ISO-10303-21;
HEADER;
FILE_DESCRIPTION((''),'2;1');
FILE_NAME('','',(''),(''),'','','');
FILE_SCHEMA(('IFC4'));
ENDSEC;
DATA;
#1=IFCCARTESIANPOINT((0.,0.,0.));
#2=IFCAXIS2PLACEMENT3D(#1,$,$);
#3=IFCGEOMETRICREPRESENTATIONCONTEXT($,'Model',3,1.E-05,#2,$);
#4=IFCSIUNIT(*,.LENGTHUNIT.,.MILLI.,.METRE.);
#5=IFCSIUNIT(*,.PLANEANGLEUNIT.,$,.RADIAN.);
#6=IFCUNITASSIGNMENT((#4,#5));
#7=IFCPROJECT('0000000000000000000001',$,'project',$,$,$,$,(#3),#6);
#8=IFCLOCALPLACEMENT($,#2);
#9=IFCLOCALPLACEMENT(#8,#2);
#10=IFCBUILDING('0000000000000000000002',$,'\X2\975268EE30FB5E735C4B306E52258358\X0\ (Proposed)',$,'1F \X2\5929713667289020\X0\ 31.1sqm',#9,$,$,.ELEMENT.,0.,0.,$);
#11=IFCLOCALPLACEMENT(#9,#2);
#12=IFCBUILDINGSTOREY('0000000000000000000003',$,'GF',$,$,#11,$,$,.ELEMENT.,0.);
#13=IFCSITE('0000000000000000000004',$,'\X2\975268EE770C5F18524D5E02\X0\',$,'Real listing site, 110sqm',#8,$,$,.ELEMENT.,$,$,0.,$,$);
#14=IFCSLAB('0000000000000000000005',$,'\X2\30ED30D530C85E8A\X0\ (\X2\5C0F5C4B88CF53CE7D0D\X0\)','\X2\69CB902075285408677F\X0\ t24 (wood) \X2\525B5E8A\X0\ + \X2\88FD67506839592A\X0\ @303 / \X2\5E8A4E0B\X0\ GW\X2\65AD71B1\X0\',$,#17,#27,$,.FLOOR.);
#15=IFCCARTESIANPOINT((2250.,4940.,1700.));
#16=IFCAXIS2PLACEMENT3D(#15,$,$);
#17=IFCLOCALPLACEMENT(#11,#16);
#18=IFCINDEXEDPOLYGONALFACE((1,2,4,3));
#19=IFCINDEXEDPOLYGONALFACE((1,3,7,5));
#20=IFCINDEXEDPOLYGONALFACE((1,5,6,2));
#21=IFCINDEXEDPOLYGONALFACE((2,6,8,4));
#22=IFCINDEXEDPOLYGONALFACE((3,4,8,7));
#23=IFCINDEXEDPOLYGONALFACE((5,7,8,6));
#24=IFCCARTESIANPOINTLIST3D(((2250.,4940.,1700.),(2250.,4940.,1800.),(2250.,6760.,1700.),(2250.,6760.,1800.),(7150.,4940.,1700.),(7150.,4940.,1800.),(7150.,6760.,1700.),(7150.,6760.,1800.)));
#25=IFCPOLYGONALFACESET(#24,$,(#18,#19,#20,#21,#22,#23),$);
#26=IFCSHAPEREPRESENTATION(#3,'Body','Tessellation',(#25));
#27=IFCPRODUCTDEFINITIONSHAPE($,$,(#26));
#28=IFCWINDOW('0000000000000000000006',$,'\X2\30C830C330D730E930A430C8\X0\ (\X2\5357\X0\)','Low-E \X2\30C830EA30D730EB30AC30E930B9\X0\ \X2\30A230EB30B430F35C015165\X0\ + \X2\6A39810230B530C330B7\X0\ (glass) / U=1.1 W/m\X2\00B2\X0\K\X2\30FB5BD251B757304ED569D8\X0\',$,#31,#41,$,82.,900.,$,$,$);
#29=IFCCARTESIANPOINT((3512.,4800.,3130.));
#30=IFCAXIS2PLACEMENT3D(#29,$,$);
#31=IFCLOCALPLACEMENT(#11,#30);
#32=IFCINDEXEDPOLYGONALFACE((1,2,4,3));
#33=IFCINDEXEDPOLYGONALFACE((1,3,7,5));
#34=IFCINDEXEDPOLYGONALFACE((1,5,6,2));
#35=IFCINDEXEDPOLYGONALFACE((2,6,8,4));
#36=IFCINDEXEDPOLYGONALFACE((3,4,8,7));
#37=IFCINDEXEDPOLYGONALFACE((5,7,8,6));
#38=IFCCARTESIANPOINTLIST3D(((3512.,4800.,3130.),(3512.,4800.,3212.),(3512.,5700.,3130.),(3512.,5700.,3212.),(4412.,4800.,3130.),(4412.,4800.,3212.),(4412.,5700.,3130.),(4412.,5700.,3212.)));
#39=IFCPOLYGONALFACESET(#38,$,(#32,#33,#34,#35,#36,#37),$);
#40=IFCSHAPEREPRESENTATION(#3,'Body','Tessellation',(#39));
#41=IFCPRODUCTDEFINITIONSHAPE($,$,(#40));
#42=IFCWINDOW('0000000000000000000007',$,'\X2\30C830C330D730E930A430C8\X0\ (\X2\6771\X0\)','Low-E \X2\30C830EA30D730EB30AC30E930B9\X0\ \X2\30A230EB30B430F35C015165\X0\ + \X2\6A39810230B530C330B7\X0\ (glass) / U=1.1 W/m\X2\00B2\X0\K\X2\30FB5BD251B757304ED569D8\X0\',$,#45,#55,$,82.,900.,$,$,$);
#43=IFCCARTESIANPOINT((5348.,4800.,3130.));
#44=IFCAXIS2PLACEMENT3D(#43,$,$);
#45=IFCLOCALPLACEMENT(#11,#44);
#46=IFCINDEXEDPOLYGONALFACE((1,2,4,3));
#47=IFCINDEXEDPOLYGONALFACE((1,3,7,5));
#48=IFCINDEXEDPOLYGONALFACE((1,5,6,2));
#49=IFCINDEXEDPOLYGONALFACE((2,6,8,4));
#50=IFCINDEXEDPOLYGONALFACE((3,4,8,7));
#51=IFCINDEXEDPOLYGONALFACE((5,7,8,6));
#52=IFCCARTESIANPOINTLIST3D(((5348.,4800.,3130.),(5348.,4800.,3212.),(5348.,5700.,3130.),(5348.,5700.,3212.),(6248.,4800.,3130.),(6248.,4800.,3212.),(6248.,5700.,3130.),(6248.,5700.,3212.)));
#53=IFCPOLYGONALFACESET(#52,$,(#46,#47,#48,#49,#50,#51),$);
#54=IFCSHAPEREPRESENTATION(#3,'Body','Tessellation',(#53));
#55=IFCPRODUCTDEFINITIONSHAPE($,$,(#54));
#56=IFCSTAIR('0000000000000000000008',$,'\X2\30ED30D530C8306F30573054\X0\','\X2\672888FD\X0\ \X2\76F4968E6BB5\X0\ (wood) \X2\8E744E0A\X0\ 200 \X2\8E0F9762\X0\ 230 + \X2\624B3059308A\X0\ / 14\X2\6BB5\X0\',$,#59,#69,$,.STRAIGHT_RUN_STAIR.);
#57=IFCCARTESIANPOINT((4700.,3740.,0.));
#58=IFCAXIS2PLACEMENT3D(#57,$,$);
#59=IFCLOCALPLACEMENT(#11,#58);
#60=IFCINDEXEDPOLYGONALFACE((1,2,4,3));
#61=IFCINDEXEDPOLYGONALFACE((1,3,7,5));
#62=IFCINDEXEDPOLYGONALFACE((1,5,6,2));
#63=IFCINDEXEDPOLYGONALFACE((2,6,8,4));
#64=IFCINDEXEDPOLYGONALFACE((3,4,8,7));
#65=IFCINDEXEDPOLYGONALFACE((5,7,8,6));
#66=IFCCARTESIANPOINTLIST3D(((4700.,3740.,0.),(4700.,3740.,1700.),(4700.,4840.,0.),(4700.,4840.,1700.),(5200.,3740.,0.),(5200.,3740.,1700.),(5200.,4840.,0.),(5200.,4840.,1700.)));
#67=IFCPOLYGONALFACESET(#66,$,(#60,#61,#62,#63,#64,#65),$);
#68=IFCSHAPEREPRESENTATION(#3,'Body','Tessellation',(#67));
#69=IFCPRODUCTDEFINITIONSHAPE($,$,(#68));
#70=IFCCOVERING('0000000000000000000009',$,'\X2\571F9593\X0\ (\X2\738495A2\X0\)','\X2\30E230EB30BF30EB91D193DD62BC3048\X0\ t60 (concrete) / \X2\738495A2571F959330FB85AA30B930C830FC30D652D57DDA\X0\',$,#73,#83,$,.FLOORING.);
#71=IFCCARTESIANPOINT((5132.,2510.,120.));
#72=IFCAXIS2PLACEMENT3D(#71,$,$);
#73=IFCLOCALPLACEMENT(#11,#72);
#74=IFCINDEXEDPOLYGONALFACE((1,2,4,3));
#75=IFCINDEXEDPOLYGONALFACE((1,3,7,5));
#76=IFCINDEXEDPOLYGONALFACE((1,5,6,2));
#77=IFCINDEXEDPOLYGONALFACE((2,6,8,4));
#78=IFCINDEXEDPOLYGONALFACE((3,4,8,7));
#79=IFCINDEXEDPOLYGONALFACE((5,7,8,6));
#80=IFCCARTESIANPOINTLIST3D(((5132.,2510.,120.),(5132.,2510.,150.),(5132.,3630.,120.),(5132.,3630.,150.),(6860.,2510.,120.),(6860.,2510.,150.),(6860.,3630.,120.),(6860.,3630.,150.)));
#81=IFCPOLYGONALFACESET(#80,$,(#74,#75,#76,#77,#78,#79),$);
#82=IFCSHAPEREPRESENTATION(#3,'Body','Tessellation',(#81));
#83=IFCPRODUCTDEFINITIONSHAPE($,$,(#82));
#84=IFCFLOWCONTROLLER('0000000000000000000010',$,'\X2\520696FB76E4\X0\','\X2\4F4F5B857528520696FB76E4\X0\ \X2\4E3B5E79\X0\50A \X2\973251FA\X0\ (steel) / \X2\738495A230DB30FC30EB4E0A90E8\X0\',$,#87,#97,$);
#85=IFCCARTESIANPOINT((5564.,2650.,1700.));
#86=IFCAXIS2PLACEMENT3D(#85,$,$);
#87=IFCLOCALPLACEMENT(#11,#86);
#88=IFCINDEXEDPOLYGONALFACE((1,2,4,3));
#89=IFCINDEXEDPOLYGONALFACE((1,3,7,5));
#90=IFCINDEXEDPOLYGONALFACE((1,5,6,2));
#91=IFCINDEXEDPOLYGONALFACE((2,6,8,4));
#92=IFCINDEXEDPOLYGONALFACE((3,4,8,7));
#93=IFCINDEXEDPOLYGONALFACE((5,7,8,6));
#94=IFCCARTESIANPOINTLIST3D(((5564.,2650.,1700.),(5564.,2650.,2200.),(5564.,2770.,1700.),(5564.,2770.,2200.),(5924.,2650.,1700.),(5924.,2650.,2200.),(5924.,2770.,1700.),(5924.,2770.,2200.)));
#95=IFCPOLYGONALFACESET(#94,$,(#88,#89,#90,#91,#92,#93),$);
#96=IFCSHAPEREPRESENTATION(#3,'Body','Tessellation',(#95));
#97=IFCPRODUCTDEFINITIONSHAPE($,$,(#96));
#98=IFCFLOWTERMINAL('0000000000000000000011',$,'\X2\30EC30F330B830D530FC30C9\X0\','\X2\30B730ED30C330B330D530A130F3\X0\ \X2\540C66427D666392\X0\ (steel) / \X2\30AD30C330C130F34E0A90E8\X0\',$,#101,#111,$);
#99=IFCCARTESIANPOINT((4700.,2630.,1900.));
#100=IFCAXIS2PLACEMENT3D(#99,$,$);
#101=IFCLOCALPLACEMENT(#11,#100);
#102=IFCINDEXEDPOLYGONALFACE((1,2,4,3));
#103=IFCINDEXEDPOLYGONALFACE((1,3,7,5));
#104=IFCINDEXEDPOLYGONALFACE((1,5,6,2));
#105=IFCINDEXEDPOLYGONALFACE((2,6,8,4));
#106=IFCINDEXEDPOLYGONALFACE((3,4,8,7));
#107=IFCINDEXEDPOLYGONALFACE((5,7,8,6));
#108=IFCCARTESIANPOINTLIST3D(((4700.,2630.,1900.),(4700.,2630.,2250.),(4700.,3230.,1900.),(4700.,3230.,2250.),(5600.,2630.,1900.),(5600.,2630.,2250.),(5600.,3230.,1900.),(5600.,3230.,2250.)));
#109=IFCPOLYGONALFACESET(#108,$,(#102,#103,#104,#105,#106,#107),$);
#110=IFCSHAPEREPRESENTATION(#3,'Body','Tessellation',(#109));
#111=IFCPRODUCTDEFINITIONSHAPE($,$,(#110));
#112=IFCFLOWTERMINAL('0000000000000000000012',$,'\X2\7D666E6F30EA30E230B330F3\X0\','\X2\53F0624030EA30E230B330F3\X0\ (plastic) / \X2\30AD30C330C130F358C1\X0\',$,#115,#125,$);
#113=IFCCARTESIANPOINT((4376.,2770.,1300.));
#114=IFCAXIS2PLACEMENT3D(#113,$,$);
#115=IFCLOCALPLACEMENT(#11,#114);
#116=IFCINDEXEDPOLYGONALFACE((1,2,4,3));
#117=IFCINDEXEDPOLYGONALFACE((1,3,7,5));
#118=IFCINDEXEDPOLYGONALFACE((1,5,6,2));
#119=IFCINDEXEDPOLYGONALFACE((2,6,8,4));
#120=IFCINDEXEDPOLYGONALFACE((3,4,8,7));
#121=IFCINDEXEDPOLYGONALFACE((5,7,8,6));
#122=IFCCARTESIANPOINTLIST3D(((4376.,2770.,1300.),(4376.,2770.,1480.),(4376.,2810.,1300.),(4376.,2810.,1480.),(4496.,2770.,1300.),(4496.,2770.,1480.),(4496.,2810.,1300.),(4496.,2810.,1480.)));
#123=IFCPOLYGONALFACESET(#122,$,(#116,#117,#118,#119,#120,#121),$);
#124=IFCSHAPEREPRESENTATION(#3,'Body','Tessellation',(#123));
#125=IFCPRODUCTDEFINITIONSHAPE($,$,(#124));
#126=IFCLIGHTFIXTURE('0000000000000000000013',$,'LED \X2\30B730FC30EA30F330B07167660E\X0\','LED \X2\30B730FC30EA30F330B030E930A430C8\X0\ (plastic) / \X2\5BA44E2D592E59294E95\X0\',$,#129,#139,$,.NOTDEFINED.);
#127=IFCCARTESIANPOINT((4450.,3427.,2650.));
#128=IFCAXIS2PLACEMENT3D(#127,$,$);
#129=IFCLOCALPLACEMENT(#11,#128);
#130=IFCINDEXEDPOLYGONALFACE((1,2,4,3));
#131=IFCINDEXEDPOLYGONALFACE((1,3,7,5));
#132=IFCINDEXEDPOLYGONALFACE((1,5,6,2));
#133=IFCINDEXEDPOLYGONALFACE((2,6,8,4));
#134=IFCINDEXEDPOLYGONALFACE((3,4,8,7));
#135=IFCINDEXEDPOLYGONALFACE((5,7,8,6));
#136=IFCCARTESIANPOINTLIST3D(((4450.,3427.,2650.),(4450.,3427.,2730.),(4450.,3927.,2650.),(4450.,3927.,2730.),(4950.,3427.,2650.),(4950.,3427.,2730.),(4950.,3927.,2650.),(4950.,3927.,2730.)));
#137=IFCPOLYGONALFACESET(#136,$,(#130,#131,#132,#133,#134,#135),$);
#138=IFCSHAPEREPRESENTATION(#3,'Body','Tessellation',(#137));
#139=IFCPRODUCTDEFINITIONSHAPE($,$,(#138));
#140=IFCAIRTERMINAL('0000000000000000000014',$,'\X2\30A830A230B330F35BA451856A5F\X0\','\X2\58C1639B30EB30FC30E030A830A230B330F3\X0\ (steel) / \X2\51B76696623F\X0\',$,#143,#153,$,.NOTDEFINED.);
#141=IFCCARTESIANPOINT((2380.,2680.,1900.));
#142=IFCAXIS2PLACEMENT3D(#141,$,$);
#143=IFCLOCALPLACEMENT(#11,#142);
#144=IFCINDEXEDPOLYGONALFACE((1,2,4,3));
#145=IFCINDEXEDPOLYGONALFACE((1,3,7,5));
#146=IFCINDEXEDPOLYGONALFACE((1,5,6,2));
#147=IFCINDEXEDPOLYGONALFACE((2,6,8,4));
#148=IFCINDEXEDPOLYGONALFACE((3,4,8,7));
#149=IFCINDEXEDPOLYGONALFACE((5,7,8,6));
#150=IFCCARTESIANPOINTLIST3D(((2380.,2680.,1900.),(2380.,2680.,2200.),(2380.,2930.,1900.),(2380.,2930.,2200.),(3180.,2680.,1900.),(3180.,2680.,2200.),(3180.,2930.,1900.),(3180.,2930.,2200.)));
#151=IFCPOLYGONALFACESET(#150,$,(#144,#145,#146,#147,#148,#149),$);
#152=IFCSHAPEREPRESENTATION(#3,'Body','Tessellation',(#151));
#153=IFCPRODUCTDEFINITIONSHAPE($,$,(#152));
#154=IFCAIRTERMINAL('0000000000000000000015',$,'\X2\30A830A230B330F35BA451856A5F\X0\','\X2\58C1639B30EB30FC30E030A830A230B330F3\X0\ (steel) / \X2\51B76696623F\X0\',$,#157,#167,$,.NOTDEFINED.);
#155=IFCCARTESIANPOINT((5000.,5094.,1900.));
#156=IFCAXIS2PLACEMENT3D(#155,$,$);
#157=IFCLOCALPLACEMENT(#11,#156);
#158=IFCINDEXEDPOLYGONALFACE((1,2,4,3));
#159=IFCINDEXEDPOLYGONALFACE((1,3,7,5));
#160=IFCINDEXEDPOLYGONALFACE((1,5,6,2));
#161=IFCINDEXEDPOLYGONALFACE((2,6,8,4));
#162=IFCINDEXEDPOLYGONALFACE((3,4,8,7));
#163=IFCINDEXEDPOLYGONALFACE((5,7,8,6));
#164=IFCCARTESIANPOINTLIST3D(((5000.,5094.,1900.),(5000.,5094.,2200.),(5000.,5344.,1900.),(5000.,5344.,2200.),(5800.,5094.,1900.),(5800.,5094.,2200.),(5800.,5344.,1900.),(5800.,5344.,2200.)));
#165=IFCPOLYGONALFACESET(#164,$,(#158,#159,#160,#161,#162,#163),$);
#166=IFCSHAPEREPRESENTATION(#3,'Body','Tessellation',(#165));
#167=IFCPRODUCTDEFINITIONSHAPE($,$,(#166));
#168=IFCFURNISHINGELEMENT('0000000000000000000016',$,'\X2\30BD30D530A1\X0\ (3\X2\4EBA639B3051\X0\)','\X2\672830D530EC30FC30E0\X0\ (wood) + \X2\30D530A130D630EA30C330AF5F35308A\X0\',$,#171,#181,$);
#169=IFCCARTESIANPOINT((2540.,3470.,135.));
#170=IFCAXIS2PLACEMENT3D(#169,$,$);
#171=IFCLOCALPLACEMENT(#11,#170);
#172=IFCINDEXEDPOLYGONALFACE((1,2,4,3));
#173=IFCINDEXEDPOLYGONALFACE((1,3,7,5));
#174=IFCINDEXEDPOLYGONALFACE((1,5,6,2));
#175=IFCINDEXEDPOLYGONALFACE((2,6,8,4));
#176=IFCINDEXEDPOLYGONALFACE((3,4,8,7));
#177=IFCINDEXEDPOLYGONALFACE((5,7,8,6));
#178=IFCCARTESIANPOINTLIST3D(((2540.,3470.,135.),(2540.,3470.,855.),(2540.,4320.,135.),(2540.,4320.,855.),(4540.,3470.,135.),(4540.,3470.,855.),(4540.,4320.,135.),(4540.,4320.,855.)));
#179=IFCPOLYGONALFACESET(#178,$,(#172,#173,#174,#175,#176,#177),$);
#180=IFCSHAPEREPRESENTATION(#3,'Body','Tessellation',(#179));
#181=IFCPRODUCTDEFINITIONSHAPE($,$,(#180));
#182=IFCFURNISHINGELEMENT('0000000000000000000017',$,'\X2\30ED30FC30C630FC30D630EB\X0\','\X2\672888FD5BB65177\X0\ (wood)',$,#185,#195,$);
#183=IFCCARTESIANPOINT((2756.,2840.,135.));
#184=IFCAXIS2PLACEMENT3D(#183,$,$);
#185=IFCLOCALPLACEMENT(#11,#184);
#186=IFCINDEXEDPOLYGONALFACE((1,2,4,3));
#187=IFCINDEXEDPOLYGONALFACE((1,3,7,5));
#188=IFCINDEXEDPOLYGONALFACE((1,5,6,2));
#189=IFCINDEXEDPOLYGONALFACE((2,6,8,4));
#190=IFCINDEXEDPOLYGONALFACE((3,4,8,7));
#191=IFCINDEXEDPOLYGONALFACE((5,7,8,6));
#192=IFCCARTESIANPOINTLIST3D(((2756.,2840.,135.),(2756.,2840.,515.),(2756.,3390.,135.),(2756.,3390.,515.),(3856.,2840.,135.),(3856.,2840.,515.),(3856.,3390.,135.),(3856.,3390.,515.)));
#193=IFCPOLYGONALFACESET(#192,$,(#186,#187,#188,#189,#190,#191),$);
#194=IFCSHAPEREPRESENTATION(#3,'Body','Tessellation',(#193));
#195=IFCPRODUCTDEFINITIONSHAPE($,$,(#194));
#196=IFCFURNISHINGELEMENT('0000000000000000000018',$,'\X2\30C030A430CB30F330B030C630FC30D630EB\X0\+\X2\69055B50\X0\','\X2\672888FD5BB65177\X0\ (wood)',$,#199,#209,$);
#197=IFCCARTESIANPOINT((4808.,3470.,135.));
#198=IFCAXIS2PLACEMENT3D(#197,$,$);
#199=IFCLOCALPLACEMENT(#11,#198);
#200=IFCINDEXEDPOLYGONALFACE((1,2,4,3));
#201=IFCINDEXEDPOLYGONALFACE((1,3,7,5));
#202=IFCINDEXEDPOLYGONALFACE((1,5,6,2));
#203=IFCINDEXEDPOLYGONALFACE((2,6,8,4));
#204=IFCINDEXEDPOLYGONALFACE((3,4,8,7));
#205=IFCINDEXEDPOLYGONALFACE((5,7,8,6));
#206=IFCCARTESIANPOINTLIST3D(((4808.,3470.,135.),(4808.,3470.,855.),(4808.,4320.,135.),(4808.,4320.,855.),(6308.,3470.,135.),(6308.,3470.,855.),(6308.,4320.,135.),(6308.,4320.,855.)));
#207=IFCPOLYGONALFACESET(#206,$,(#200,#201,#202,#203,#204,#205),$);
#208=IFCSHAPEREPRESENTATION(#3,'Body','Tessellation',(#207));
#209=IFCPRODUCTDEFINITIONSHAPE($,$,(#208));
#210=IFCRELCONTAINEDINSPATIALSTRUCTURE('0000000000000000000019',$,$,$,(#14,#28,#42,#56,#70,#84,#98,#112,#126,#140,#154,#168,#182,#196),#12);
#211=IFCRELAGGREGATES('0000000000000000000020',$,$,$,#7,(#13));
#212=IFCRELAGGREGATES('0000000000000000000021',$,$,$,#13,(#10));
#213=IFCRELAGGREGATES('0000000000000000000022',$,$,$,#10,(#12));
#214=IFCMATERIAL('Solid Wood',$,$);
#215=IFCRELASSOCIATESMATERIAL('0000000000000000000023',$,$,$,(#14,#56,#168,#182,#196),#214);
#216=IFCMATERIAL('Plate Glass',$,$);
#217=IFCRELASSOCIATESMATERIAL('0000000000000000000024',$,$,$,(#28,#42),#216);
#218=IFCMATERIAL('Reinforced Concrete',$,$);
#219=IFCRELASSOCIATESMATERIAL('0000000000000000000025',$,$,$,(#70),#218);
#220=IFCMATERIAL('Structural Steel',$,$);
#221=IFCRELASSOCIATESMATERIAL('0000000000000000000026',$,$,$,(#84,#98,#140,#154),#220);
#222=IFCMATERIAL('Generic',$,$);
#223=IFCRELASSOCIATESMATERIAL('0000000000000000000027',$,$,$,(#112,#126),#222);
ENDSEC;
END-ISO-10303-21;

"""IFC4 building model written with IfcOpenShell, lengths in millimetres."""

from ifc_helpers import new_model, si_unit, frame, frame_2d, origin, place, context, project, spatial, rectangle, extrude, material, element, save


model = new_model("IFC4")

# Units and contexts
model_context = context("Model", 3, precision=1e-05, world=origin())
ifc_project = project(units=[si_unit("LENGTHUNIT", "METRE", prefix="MILLI"), si_unit("PLANEANGLEUNIT", "RADIAN")], contexts=[model_context])

# Site, building, storey
site_placement = place(None, origin())
site = spatial("IfcSite", under=ifc_project, at=site_placement, Name="青森県弘前市", ObjectType="Real listing site, 110sqm", CompositionType="ELEMENT", RefElevation=0.0)
building_placement = place(site_placement, origin())
building = spatial("IfcBuilding", under=site, at=building_placement, Name="青森・平屋の別荘 (Proposed)", ObjectType="1F 天然木造 31.1sqm", CompositionType="ELEMENT", ElevationOfRefHeight=0.0, ElevationOfTerrain=0.0)
storey_placement = place(building_placement, origin())
storey = spatial("IfcBuildingStorey", under=building, at=storey_placement, Name="GF", CompositionType="ELEMENT", Elevation=0.0)

# Shared definitions
ifc_material_1 = material(Name="Solid Wood")

# Slab
slab_placement = place(storey_placement, frame((2250.0, 4940.0, 1700.0)))
element("IfcSlab", 1, at=slab_placement, inside=storey, material=ifc_material_1, Name="ロフト床 (小屋裏収納)", Description="構造用合板 t24 (wood) 剛床 + 製材根太 @303 / 床下 GW断熱", PredefinedType="FLOOR", context=model_context, shape_type="SweptSolid", body=[
    extrude(rectangle(XDim=4900.0, YDim=1820.0, at=frame_2d((2450.0, 910.0))), frame((2250.0, 4940.0, 1700.0)), (0.0, 0.0, 1.0), 100.0),
])

# Windows
ifc_material_2 = material(Name="Plate Glass")
window_1_placement = place(storey_placement, frame((3512.0, 4800.0, 3130.0)))
element("IfcWindow", 2, at=window_1_placement, inside=storey, material=ifc_material_2, Name="トップライト (南)", Description="Low-E トリプルガラス アルゴン封入 + 樹脂サッシ (glass) / U=1.1 W/m²K・寒冷地仕様", OverallHeight=82.0, OverallWidth=900.0, context=model_context, shape_type="SweptSolid", body=[
    extrude(rectangle(XDim=900.0, YDim=900.0, at=frame_2d((450.0, 450.0))), frame((3512.0, 4800.0, 3130.0)), (0.0, 0.0, 1.0), 82.0),
])
window_2_placement = place(storey_placement, frame((5348.0, 4800.0, 3130.0)))
element("IfcWindow", 3, at=window_2_placement, inside=storey, material=ifc_material_2, Name="トップライト (東)", Description="Low-E トリプルガラス アルゴン封入 + 樹脂サッシ (glass) / U=1.1 W/m²K・寒冷地仕様", OverallHeight=82.0, OverallWidth=900.0, context=model_context, shape_type="SweptSolid", body=[
    extrude(rectangle(XDim=900.0, YDim=900.0, at=frame_2d((450.0, 450.0))), frame((5348.0, 4800.0, 3130.0)), (0.0, 0.0, 1.0), 82.0),
])

# Stair
stair_placement = place(storey_placement, frame((4700.0, 3740.0, 0.0)))
element("IfcStair", 4, at=stair_placement, inside=storey, material=ifc_material_1, Name="ロフトはしご", Description="木製 直階段 (wood) 蹴上 200 踏面 230 + 手すり / 14段", PredefinedType="STRAIGHT_RUN_STAIR", context=model_context, shape_type="SweptSolid", body=[
    extrude(rectangle(XDim=500.0, YDim=1100.0, at=frame_2d((250.0, 550.0))), frame((4700.0, 3740.0, 0.0)), (0.0, 0.0, 1.0), 1700.0),
])

# Covering
ifc_material_3 = material(Name="Reinforced Concrete")
covering_placement = place(storey_placement, frame((5132.0, 2510.0, 120.0)))
element("IfcCovering", 5, at=covering_placement, inside=storey, material=ifc_material_3, Name="土間 (玄関)", Description="モルタル金鏝押え t60 (concrete) / 玄関土間・薪ストーブ動線", PredefinedType="FLOORING", context=model_context, shape_type="SweptSolid", body=[
    extrude(rectangle(XDim=1728.0, YDim=1120.0, at=frame_2d((864.0, 560.0))), frame((5132.0, 2510.0, 120.0)), (0.0, 0.0, 1.0), 30.0),
])

# Flow controller
ifc_material_4 = material(Name="Structural Steel")
flow_controller_placement = place(storey_placement, frame((5564.0, 2650.0, 1700.0)))
element("IfcFlowController", 6, at=flow_controller_placement, inside=storey, material=ifc_material_4, Name="分電盤", Description="住宅用分電盤 主幹50A 露出 (steel) / 玄関ホール上部", context=model_context, shape_type="SweptSolid", body=[
    extrude(rectangle(XDim=360.0, YDim=120.0, at=frame_2d((180.0, 60.0))), frame((5564.0, 2650.0, 1700.0)), (0.0, 0.0, 1.0), 500.0),
])

# Flow terminals
flow_terminal_1_placement = place(storey_placement, frame((4700.0, 2630.0, 1900.0)))
element("IfcFlowTerminal", 7, at=flow_terminal_1_placement, inside=storey, material=ifc_material_4, Name="レンジフード", Description="シロッコファン 同時給排 (steel) / キッチン上部", context=model_context, shape_type="SweptSolid", body=[
    extrude(rectangle(XDim=900.0, YDim=600.0, at=frame_2d((450.0, 300.0))), frame((4700.0, 2630.0, 1900.0)), (0.0, 0.0, 1.0), 350.0),
])
ifc_material_5 = material(Name="Generic")
flow_terminal_2_placement = place(storey_placement, frame((4376.0, 2770.0, 1300.0)))
element("IfcFlowTerminal", 8, at=flow_terminal_2_placement, inside=storey, material=ifc_material_5, Name="給湯リモコン", Description="台所リモコン (plastic) / キッチン壁", context=model_context, shape_type="SweptSolid", body=[
    extrude(rectangle(XDim=120.0, YDim=40.0, at=frame_2d((60.0, 20.0))), frame((4376.0, 2770.0, 1300.0)), (0.0, 0.0, 1.0), 180.0),
])

# Light fixture
light_fixture_placement = place(storey_placement, frame((4450.0, 3427.0, 2650.0)))
element("IfcLightFixture", 9, at=light_fixture_placement, inside=storey, material=ifc_material_5, Name="LED シーリング照明", Description="LED シーリングライト (plastic) / 室中央天井", PredefinedType="NOTDEFINED", context=model_context, shape_type="SweptSolid", body=[
    extrude(rectangle(XDim=500.0, YDim=500.0, at=frame_2d((250.0, 250.0))), frame((4450.0, 3427.0, 2650.0)), (0.0, 0.0, 1.0), 80.0),
])

# Air terminals
air_terminal_1_placement = place(storey_placement, frame((2380.0, 2680.0, 1900.0)))
element("IfcAirTerminal", 10, at=air_terminal_1_placement, inside=storey, material=ifc_material_4, Name="エアコン室内機", Description="壁掛ルームエアコン (steel) / 冷暖房", PredefinedType="NOTDEFINED", context=model_context, shape_type="SweptSolid", body=[
    extrude(rectangle(XDim=800.0, YDim=250.0, at=frame_2d((400.0, 125.0))), frame((2380.0, 2680.0, 1900.0)), (0.0, 0.0, 1.0), 300.0),
])
air_terminal_2_placement = place(storey_placement, frame((5000.0, 5094.0, 1900.0)))
element("IfcAirTerminal", 11, at=air_terminal_2_placement, inside=storey, material=ifc_material_4, Name="エアコン室内機", Description="壁掛ルームエアコン (steel) / 冷暖房", PredefinedType="NOTDEFINED", context=model_context, shape_type="SweptSolid", body=[
    extrude(rectangle(XDim=800.0, YDim=250.0, at=frame_2d((400.0, 125.0))), frame((5000.0, 5094.0, 1900.0)), (0.0, 0.0, 1.0), 300.0),
])

# Furnishing elements
furnishing_1_placement = place(storey_placement, frame((2540.0, 3470.0, 135.0)))
element("IfcFurnishingElement", 12, at=furnishing_1_placement, inside=storey, material=ifc_material_1, Name="ソファ (3人掛け)", Description="木フレーム (wood) + ファブリック張り", context=model_context, shape_type="SweptSolid", body=[
    extrude(rectangle(XDim=2000.0, YDim=850.0, at=frame_2d((1000.0, 425.0))), frame((2540.0, 3470.0, 135.0)), (0.0, 0.0, 1.0), 720.0),
])
furnishing_2_placement = place(storey_placement, frame((2756.0, 2840.0, 135.0)))
element("IfcFurnishingElement", 13, at=furnishing_2_placement, inside=storey, material=ifc_material_1, Name="ローテーブル", Description="木製家具 (wood)", context=model_context, shape_type="SweptSolid", body=[
    extrude(rectangle(XDim=1100.0, YDim=550.0, at=frame_2d((550.0, 275.0))), frame((2756.0, 2840.0, 135.0)), (0.0, 0.0, 1.0), 380.0),
])
furnishing_3_placement = place(storey_placement, frame((4808.0, 3470.0, 135.0)))
element("IfcFurnishingElement", 14, at=furnishing_3_placement, inside=storey, material=ifc_material_1, Name="ダイニングテーブル+椅子", Description="木製家具 (wood)", context=model_context, shape_type="SweptSolid", body=[
    extrude(rectangle(XDim=1500.0, YDim=850.0, at=frame_2d((750.0, 425.0))), frame((4808.0, 3470.0, 135.0)), (0.0, 0.0, 1.0), 720.0),
])

save(model, "model.ifc")
